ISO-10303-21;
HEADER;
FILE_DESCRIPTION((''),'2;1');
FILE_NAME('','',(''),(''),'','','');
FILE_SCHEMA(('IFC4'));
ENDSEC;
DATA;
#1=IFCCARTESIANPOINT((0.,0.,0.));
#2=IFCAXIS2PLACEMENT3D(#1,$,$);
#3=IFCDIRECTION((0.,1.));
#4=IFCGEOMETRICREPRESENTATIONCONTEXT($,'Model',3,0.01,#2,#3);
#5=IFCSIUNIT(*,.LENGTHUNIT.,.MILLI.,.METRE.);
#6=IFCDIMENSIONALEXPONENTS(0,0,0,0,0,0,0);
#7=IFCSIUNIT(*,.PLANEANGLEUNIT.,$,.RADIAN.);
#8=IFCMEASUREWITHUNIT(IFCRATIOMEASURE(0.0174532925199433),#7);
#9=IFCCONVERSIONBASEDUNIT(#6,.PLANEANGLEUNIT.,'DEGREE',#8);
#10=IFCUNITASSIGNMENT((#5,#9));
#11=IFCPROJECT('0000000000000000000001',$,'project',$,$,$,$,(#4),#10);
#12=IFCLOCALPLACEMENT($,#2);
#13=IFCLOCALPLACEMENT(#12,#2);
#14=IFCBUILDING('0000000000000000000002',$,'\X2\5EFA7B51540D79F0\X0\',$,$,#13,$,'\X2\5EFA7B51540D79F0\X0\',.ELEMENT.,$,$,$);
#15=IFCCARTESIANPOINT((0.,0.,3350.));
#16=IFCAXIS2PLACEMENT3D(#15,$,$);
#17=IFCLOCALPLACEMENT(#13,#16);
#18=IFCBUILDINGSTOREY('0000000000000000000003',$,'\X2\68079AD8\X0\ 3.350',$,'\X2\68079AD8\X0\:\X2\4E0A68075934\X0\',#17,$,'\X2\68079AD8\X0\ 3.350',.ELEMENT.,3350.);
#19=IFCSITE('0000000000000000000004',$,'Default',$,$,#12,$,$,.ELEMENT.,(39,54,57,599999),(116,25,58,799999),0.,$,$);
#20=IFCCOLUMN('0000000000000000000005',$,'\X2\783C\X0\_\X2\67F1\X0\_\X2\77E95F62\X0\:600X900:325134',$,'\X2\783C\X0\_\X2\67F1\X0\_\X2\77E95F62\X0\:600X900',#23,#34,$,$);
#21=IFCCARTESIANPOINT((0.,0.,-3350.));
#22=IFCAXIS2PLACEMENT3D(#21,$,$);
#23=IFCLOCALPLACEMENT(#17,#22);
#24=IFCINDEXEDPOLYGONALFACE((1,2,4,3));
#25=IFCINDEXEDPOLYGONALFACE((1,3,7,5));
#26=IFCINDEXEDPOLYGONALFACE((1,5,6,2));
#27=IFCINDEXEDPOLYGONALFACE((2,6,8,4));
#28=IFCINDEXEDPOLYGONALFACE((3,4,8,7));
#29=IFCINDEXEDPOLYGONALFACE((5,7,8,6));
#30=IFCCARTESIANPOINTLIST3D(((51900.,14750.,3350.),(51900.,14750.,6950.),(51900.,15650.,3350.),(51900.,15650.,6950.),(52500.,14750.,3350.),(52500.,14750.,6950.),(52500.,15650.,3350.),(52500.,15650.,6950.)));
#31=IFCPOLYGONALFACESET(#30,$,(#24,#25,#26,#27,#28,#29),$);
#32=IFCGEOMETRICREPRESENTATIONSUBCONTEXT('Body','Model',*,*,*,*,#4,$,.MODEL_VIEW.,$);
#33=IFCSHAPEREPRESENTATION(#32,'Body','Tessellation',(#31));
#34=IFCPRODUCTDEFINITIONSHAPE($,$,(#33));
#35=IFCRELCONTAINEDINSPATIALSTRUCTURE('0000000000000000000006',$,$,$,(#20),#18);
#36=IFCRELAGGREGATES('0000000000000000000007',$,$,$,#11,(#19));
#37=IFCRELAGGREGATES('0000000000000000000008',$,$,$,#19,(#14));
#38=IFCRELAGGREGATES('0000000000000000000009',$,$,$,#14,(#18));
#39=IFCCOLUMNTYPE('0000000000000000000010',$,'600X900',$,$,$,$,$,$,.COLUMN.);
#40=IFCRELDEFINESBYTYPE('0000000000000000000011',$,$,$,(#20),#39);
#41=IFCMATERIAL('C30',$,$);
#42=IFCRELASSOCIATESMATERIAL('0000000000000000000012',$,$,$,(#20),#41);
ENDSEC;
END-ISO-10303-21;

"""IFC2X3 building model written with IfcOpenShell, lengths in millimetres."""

from ifc_helpers import new_model, entity, si_unit, converted_unit, direction, frame, origin, origin_2d_with_axis, place, context, subcontext, project, spatial, rectangle, extrude, source, transform, mapped, material, type_object, type_shapes, element, save


model = new_model("IFC2X3")

# Units and contexts
model_context = context("Model", 3, precision=0.01, world=origin(), true_north=direction((0.0, 1.0)))
body_context = subcontext(model_context, "Body", "Model", "MODEL_VIEW")
ifc_project = project(units=[si_unit("LENGTHUNIT", "METRE", prefix="MILLI"), converted_unit("PLANEANGLEUNIT", "DEGREE", entity("IfcRatioMeasure", 0.0174532925199433), si_unit("PLANEANGLEUNIT", "RADIAN"), dimensions=[0, 0, 0, 0, 0, 0, 0])], contexts=[model_context])

# Site, building, storey
site_placement = place(None, origin())
site = spatial("IfcSite", under=ifc_project, at=site_placement, Name="Default", CompositionType="ELEMENT", RefLatitude=(39, 54, 57, 599999), RefLongitude=(116, 25, 58, 799999), RefElevation=0.0)
building_placement = place(site_placement, origin())
building = spatial("IfcBuilding", under=site, at=building_placement, Name="建筑名称", LongName="建筑名称", CompositionType="ELEMENT")
storey_placement = place(building_placement, frame((0.0, 0.0, 3350.0)))
storey = spatial("IfcBuildingStorey", under=building, at=storey_placement, Name="标高 3.350", ObjectType="标高:上标头", LongName="标高 3.350", CompositionType="ELEMENT", Elevation=3350.0)

# Column
ifc_material = material(Name="C30")
column_type_1 = type_object("IfcColumnType", Name="600X900", PredefinedType="COLUMN")
shared_shape_1 = source(origin(), body_context, "Body", "SweptSolid", [
    extrude(rectangle(XDim=900.0, YDim=600.0, at=origin_2d_with_axis()), frame((52200.0, 15200.0, 3350.0), z_axis=(0.0, 0.0, 1.0), x_axis=(0.0, -1.0, 0.0)), (0.0, 0.0, 1.0), 3600.0),
])
type_shapes(column_type_1, [shared_shape_1])
column_1_placement = place(storey_placement, frame((0.0, 0.0, -3350.0)))
element("IfcColumn", 1, at=column_1_placement, inside=storey, type_object=column_type_1, material=ifc_material, Name="砼_柱_矩形:600X900:325134", ObjectType="砼_柱_矩形:600X900", context=body_context, shape_type="MappedRepresentation", body=[
    mapped(shared_shape_1, transform((0.0, 0.0, 0.0), scale=1.0)),
])

save(model, "model.ifc")
